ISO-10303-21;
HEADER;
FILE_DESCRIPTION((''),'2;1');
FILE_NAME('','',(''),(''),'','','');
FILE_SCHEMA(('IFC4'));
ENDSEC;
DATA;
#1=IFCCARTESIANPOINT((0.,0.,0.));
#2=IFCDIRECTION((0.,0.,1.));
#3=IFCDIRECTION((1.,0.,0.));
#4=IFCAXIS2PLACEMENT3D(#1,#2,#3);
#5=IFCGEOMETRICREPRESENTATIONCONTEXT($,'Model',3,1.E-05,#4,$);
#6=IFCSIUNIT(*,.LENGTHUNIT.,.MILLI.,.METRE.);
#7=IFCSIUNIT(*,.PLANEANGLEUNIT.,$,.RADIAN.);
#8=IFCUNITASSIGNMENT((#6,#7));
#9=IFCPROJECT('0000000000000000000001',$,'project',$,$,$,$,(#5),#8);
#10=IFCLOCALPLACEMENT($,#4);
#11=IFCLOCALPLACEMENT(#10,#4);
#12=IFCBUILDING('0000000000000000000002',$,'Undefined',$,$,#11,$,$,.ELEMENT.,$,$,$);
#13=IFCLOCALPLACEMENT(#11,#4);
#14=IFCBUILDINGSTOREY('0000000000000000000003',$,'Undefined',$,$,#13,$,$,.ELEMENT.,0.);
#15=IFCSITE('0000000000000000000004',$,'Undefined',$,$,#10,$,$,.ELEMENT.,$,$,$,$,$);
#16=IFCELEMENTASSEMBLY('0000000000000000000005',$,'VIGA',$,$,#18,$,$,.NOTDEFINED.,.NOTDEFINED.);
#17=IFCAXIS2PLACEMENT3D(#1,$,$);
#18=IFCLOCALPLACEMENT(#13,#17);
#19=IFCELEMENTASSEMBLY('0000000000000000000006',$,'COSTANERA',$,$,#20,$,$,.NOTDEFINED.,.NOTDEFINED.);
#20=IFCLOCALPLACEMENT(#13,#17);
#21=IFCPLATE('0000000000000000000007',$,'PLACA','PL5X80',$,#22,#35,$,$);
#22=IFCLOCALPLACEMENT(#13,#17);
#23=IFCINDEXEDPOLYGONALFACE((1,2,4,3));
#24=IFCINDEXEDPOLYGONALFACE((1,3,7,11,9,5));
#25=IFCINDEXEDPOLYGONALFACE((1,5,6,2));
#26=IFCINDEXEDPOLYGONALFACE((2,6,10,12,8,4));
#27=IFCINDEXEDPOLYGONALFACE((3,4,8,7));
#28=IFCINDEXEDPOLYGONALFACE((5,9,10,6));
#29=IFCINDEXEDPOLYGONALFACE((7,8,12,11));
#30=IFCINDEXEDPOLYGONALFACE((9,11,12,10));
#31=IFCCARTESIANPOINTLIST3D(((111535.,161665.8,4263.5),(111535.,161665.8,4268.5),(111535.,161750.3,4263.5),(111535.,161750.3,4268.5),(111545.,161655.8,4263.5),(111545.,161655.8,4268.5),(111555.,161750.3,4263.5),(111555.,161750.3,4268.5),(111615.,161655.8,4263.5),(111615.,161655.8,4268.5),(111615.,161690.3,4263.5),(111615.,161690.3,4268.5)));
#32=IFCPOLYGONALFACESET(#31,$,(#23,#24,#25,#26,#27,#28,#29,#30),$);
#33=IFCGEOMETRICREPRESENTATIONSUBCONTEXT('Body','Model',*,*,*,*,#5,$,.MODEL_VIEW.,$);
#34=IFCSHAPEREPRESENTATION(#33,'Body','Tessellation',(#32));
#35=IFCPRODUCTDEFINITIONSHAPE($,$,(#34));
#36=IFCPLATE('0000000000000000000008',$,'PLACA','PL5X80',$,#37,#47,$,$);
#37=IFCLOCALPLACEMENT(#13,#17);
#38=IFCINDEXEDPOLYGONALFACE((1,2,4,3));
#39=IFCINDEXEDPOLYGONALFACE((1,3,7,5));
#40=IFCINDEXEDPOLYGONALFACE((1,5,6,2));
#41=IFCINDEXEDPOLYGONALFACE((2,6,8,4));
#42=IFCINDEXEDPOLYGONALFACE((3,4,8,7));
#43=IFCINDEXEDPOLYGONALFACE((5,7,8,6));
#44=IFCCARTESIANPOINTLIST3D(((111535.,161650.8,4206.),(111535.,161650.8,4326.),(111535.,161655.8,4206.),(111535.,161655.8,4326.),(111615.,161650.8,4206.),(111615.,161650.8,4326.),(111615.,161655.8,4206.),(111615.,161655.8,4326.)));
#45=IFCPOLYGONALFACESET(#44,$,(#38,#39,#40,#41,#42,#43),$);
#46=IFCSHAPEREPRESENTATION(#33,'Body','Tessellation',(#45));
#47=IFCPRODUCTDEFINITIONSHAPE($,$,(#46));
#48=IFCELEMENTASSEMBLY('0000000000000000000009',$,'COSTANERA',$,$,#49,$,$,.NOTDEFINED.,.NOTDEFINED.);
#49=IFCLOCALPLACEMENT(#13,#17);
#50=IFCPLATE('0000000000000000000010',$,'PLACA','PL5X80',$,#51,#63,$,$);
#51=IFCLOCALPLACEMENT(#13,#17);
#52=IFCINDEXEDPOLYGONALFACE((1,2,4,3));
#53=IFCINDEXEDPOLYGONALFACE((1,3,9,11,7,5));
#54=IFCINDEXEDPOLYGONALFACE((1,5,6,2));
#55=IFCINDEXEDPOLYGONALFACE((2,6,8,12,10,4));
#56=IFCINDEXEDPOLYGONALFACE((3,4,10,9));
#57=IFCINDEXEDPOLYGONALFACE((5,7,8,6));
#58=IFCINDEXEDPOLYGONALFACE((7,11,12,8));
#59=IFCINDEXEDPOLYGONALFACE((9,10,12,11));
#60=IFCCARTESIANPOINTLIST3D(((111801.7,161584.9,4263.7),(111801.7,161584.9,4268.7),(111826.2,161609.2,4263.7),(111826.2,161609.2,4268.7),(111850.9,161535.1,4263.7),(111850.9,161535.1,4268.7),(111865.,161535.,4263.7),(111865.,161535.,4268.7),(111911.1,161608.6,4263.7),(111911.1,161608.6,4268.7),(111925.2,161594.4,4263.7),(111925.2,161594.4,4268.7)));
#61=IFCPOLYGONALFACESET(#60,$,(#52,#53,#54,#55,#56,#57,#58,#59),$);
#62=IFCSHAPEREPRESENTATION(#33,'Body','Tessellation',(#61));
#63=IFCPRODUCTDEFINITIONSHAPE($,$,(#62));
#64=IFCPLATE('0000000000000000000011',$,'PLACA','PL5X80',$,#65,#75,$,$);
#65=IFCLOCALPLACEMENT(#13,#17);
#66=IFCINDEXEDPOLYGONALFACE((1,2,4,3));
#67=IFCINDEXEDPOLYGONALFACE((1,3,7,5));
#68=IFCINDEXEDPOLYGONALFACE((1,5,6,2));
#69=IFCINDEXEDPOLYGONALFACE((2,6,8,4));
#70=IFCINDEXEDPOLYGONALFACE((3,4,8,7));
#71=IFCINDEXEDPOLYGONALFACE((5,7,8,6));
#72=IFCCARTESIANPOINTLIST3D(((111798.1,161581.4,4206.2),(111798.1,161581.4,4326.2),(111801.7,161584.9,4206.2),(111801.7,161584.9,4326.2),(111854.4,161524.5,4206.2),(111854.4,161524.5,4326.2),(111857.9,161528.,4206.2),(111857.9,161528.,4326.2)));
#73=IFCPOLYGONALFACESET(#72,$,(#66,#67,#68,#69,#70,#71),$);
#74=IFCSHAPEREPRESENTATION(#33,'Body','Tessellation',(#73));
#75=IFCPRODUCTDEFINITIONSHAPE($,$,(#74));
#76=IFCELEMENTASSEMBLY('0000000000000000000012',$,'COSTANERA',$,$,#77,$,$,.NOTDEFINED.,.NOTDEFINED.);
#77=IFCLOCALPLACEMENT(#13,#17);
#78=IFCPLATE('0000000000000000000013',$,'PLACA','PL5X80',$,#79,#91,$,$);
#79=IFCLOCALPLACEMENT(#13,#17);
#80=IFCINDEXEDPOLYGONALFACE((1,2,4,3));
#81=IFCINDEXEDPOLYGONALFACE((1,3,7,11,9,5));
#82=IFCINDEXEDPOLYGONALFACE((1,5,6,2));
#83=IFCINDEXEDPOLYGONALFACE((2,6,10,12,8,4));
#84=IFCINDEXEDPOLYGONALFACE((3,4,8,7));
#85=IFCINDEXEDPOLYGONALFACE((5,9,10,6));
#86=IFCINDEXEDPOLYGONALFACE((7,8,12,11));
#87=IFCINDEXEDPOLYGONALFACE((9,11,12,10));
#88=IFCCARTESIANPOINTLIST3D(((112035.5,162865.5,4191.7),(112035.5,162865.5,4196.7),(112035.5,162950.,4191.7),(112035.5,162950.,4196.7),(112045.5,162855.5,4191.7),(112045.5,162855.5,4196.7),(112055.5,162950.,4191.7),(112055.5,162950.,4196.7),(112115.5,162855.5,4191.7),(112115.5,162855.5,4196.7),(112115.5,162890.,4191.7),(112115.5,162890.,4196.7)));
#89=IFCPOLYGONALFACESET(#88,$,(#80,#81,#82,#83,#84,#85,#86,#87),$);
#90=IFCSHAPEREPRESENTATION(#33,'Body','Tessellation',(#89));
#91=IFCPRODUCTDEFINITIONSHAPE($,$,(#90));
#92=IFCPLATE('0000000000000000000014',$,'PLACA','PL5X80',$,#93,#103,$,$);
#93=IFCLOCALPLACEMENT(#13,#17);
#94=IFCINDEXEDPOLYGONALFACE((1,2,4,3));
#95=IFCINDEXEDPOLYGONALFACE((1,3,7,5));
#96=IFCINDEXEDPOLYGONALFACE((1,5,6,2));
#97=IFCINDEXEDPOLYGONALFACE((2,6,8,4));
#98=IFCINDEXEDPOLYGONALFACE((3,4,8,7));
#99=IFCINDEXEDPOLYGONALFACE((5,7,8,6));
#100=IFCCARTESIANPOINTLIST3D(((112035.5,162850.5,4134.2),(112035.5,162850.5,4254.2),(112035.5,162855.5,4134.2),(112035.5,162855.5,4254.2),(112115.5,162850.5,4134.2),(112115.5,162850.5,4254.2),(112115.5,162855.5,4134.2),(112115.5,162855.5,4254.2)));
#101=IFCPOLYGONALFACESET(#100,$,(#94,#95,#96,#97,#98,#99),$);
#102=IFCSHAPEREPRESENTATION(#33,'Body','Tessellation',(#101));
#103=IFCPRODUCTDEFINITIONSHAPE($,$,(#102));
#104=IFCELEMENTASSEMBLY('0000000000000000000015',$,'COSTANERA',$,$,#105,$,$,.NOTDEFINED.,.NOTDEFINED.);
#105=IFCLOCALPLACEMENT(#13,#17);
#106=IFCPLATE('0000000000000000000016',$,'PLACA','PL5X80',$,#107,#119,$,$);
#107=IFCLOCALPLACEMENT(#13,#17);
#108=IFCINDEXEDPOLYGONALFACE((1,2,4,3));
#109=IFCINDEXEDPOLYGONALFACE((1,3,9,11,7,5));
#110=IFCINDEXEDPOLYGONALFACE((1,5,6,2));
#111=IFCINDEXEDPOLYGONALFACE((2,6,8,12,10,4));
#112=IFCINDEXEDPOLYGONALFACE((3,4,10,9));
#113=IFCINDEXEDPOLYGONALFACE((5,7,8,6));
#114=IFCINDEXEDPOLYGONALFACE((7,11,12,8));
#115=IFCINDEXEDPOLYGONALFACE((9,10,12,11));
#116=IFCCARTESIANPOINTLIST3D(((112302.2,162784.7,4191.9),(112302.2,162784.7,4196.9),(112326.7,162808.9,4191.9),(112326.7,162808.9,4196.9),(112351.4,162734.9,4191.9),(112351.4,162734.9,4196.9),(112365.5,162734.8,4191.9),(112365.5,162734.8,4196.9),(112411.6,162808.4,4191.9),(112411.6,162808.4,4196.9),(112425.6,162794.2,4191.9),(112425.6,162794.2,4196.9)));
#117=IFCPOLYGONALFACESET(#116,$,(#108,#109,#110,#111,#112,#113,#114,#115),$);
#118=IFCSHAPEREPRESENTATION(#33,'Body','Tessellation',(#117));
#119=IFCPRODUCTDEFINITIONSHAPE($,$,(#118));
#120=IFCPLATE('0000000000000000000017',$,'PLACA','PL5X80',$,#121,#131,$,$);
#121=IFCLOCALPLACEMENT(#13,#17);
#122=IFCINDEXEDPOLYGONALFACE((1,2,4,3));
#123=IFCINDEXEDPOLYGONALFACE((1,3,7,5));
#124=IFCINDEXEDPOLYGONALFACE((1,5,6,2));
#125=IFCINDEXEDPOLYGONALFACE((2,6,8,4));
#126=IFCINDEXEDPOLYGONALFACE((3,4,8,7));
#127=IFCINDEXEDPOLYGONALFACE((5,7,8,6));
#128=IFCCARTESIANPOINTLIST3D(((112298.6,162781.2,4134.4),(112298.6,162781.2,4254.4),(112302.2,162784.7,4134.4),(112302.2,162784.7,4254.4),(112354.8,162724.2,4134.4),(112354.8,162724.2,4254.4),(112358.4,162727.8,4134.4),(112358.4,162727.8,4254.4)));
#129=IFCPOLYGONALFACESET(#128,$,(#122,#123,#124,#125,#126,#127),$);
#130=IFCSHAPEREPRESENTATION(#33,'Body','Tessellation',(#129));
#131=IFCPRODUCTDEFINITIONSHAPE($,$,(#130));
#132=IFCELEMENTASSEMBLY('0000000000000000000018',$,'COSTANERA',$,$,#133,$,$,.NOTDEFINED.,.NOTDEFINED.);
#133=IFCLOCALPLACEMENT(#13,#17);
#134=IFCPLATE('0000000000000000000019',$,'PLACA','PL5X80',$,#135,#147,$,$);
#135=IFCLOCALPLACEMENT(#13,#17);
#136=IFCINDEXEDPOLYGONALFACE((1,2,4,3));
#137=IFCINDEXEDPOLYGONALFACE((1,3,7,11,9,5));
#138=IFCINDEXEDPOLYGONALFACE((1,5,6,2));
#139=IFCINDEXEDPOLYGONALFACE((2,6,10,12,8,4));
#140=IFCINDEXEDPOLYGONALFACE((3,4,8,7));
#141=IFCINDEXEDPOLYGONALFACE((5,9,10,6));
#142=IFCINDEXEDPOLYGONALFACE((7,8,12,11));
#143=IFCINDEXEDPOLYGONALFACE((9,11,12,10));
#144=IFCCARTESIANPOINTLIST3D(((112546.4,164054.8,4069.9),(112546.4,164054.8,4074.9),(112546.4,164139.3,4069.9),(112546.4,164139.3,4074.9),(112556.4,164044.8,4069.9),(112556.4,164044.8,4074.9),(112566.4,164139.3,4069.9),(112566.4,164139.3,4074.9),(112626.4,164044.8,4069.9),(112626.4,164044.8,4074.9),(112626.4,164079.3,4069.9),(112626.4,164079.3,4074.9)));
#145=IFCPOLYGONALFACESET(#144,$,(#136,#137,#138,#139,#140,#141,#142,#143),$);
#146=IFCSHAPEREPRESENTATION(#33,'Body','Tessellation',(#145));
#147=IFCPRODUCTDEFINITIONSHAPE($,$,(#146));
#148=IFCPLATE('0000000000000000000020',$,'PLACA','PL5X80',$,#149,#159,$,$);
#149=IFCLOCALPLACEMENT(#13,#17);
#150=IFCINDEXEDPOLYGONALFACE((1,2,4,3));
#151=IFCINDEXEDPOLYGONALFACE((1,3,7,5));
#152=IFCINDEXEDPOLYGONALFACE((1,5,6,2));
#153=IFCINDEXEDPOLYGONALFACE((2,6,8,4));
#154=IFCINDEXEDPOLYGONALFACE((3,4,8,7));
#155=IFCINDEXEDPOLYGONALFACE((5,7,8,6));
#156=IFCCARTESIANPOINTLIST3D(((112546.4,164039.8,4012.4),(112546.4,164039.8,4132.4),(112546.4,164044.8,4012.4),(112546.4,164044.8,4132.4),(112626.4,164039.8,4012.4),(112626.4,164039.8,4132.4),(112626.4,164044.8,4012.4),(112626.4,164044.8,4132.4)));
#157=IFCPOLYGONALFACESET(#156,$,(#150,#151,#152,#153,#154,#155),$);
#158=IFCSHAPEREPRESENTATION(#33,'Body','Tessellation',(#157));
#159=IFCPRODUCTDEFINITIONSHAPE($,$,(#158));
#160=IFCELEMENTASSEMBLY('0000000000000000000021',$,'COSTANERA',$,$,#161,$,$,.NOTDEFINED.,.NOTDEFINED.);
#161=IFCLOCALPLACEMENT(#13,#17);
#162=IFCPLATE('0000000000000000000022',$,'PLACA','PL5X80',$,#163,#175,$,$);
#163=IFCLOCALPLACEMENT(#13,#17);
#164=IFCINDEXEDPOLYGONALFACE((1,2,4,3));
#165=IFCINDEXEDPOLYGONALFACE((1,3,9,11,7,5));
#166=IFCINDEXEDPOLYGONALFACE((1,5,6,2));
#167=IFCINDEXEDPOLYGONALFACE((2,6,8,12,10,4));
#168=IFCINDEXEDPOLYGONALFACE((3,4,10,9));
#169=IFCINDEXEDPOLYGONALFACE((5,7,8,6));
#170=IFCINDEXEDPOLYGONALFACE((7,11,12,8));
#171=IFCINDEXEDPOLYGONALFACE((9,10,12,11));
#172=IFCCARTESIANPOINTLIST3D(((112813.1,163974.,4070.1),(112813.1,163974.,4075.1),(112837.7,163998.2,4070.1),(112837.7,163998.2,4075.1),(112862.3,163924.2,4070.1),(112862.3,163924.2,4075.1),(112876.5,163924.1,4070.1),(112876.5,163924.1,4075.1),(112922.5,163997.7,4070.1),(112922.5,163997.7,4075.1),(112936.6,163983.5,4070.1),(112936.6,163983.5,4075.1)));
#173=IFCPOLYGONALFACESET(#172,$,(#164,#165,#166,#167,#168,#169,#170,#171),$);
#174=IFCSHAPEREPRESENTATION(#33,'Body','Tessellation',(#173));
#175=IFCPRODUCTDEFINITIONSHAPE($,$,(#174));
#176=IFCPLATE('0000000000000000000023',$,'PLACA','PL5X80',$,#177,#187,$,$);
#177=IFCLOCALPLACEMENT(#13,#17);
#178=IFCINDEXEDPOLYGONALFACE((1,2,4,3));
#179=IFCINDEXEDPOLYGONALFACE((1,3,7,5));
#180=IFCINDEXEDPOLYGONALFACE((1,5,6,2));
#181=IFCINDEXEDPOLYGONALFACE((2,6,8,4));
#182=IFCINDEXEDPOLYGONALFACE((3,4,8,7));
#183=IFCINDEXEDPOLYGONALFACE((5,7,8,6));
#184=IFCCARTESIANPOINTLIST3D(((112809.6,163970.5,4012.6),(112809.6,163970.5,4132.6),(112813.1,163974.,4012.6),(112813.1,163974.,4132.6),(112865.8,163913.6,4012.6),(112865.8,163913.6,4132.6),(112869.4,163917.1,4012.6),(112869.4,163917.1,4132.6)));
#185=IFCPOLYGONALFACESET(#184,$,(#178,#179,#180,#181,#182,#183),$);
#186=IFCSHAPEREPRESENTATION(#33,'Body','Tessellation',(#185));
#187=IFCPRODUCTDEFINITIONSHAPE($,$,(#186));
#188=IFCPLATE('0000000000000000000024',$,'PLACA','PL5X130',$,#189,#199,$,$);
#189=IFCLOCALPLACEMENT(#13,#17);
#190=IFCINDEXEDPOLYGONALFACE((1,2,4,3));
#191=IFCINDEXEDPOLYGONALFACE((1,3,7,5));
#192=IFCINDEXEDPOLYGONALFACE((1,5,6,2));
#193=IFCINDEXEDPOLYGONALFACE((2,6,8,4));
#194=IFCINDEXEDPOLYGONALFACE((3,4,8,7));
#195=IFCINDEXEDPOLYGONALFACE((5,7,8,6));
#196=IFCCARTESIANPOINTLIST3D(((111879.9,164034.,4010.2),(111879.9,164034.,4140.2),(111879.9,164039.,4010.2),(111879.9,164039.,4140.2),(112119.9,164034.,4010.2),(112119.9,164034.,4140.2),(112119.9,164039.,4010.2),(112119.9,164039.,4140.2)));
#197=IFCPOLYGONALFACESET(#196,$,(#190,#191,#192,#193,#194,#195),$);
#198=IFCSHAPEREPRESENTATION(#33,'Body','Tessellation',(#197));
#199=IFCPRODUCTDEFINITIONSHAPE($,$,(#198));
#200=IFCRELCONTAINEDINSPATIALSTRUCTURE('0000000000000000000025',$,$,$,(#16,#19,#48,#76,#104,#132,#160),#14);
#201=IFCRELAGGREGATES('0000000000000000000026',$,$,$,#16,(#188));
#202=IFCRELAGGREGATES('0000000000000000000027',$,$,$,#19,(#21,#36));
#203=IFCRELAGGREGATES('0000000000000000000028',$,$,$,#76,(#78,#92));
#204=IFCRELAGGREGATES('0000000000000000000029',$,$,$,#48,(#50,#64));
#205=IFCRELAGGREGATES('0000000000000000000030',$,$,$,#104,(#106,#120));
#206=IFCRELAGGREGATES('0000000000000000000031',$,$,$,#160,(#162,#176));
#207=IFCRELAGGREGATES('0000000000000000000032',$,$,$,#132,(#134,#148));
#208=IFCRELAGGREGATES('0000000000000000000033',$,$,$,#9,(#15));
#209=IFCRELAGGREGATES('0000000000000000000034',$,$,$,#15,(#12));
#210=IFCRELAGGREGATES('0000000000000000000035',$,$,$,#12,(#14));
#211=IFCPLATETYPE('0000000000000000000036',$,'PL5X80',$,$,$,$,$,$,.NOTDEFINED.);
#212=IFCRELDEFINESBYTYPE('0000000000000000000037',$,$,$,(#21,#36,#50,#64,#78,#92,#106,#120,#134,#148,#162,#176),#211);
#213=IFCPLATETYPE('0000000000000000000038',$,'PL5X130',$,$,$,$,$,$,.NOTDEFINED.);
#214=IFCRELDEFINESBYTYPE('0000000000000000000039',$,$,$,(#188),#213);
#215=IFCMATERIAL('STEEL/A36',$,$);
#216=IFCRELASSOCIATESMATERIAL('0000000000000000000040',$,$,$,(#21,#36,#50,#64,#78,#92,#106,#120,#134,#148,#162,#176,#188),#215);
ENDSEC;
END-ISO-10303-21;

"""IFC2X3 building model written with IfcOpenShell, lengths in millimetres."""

from ifc_helpers import new_model, si_unit, frame, origin_with_axes, place, context, subcontext, project, spatial, polyline, outline, extrude, material, type_object, element, aggregate, save


model = new_model("IFC2X3")

# Units and contexts
model_context = context("Model", 3, precision=1e-05, world=origin_with_axes())
body_context = subcontext(model_context, "Body", "Model", "MODEL_VIEW")
ifc_project = project(units=[si_unit("LENGTHUNIT", "METRE", prefix="MILLI"), si_unit("PLANEANGLEUNIT", "RADIAN")], contexts=[model_context])

# Site, building, storey
site_placement = place(None, origin_with_axes())
site = spatial("IfcSite", under=ifc_project, at=site_placement, Name="Undefined", CompositionType="ELEMENT")
building_placement = place(site_placement, origin_with_axes())
building = spatial("IfcBuilding", under=site, at=building_placement, Name="Undefined", CompositionType="ELEMENT")
storey_placement = place(building_placement, origin_with_axes())
storey = spatial("IfcBuildingStorey", under=building, at=storey_placement, Name="Undefined", CompositionType="ELEMENT", Elevation=0.0)

# Shared definitions
ifc_material_1 = material(Name="STEEL/A36")

# Element assembly
assembly_1_placement = place(storey_placement, origin_with_axes())
assembly_1 = element("IfcElementAssembly", 1, at=assembly_1_placement, inside=storey, Name="VIGA", AssemblyPlace="NOTDEFINED", PredefinedType="NOTDEFINED")

# Element assemblies, plates
assembly_2_placement = place(storey_placement, origin_with_axes())
assembly_2 = element("IfcElementAssembly", 2, at=assembly_2_placement, inside=storey, Name="COSTANERA", AssemblyPlace="NOTDEFINED", PredefinedType="NOTDEFINED")
plate_type_1 = type_object("IfcPlateType", Name="PL5X80", PredefinedType="NOTDEFINED")
plate_1_placement = place(assembly_2_placement, frame((111615.0, 161655.8, 4266.0), z_axis=(-0.000004, -0.000004, -1.0), x_axis=(-1.0, 0.0, 0.000004)))
plate_1 = element("IfcPlate", 3, at=plate_1_placement, type_object=plate_type_1, material=ifc_material_1, Name="PLACA", Description="PL5X80", context=body_context, shape_type="SweptSolid", body=[
    extrude(outline(polyline([(0.0, 0.0), (70.0, 0.0), (80.0, 10.0), (80.0, 94.5), (60.0, 94.5), (0.0, 34.5), (0.0, 0.0)])), frame((0.0, 0.0, -2.5), z_axis=(0.0, 0.0, 1.0), x_axis=(1.0, 0.0, 0.0)), (0.0, 0.0, 1.0), 5.0),
])
plate_2_placement = place(assembly_2_placement, frame((111615.0, 161653.3, 4206.0), z_axis=(0.0, 1.0, -0.000004), x_axis=(-1.0, 0.0, 0.000004)))
plate_2 = element("IfcPlate", 4, at=plate_2_placement, type_object=plate_type_1, material=ifc_material_1, Name="PLACA", Description="PL5X80", context=body_context, shape_type="SweptSolid", body=[
    extrude(outline(polyline([(0.0, 0.0), (80.0, 0.0), (80.0, 120.0), (0.0, 120.0), (0.0, 0.0)])), frame((0.0, 0.0, -2.5), z_axis=(0.0, 0.0, 1.0), x_axis=(1.0, 0.0, 0.0)), (0.0, 0.0, 1.0), 5.0),
])
assembly_3_placement = place(storey_placement, origin_with_axes())
assembly_3 = element("IfcElementAssembly", 5, at=assembly_3_placement, inside=storey, Name="COSTANERA", AssemblyPlace="NOTDEFINED", PredefinedType="NOTDEFINED")
plate_3_placement = place(assembly_3_placement, frame((111801.7, 161584.9, 4266.2), z_axis=(0.000004, 0.000004, 1.0), x_axis=(0.702758, -0.711429, 0.0)))
plate_3 = element("IfcPlate", 6, at=plate_3_placement, type_object=plate_type_1, material=ifc_material_1, Name="PLACA", Description="PL5X80", context=body_context, shape_type="SweptSolid", body=[
    extrude(outline(polyline([(0.0, 0.0), (70.0, 0.0), (80.0, 10.0), (80.0, 94.5), (60.0, 94.5), (0.0, 34.5), (0.0, 0.0)])), frame((0.0, 0.0, -2.5), z_axis=(0.0, 0.0, 1.0), x_axis=(1.0, 0.0, 0.0)), (0.0, 0.0, 1.0), 5.0),
])
plate_4_placement = place(assembly_3_placement, frame((111799.9, 161583.2, 4326.2), z_axis=(0.711429, 0.702758, -0.000006), x_axis=(0.702758, -0.711429, 0.0)))
plate_4 = element("IfcPlate", 7, at=plate_4_placement, type_object=plate_type_1, material=ifc_material_1, Name="PLACA", Description="PL5X80", context=body_context, shape_type="SweptSolid", body=[
    extrude(outline(polyline([(0.0, 0.0), (80.0, 0.0), (80.0, 120.0), (0.0, 120.0), (0.0, 0.0)])), frame((0.0, 0.0, -2.5), z_axis=(0.0, 0.0, 1.0), x_axis=(1.0, 0.0, 0.0)), (0.0, 0.0, 1.0), 5.0),
])
assembly_4_placement = place(storey_placement, origin_with_axes())
assembly_4 = element("IfcElementAssembly", 8, at=assembly_4_placement, inside=storey, Name="COSTANERA", AssemblyPlace="NOTDEFINED", PredefinedType="NOTDEFINED")
plate_5_placement = place(assembly_4_placement, frame((112115.5, 162855.5, 4194.2), z_axis=(-0.000004, -0.000004, -1.0), x_axis=(-1.0, 0.0, 0.000004)))
plate_5 = element("IfcPlate", 9, at=plate_5_placement, type_object=plate_type_1, material=ifc_material_1, Name="PLACA", Description="PL5X80", context=body_context, shape_type="SweptSolid", body=[
    extrude(outline(polyline([(0.0, 0.0), (70.0, 0.0), (80.0, 10.0), (80.0, 94.5), (60.0, 94.5), (0.0, 34.5), (0.0, 0.0)])), frame((0.0, 0.0, -2.5), z_axis=(0.0, 0.0, 1.0), x_axis=(1.0, 0.0, 0.0)), (0.0, 0.0, 1.0), 5.0),
])
plate_6_placement = place(assembly_4_placement, frame((112115.5, 162853.0, 4134.2), z_axis=(0.0, 1.0, -0.000004), x_axis=(-1.0, 0.0, 0.000004)))
plate_6 = element("IfcPlate", 10, at=plate_6_placement, type_object=plate_type_1, material=ifc_material_1, Name="PLACA", Description="PL5X80", context=body_context, shape_type="SweptSolid", body=[
    extrude(outline(polyline([(0.0, 0.0), (80.0, 0.0), (80.0, 120.0), (0.0, 120.0), (0.0, 0.0)])), frame((0.0, 0.0, -2.5), z_axis=(0.0, 0.0, 1.0), x_axis=(1.0, 0.0, 0.0)), (0.0, 0.0, 1.0), 5.0),
])
assembly_5_placement = place(storey_placement, origin_with_axes())
assembly_5 = element("IfcElementAssembly", 11, at=assembly_5_placement, inside=storey, Name="COSTANERA", AssemblyPlace="NOTDEFINED", PredefinedType="NOTDEFINED")
plate_7_placement = place(assembly_5_placement, frame((112302.2, 162784.7, 4194.4), z_axis=(0.000004, 0.000004, 1.0), x_axis=(0.702758, -0.711429, 0.0)))
plate_7 = element("IfcPlate", 12, at=plate_7_placement, type_object=plate_type_1, material=ifc_material_1, Name="PLACA", Description="PL5X80", context=body_context, shape_type="SweptSolid", body=[
    extrude(outline(polyline([(0.0, 0.0), (70.0, 0.0), (80.0, 10.0), (80.0, 94.5), (60.0, 94.5), (0.0, 34.5), (0.0, 0.0)])), frame((0.0, 0.0, -2.5), z_axis=(0.0, 0.0, 1.0), x_axis=(1.0, 0.0, 0.0)), (0.0, 0.0, 1.0), 5.0),
])
plate_8_placement = place(assembly_5_placement, frame((112300.4, 162782.9, 4254.4), z_axis=(0.711429, 0.702758, -0.000006), x_axis=(0.702758, -0.711429, 0.0)))
plate_8 = element("IfcPlate", 13, at=plate_8_placement, type_object=plate_type_1, material=ifc_material_1, Name="PLACA", Description="PL5X80", context=body_context, shape_type="SweptSolid", body=[
    extrude(outline(polyline([(0.0, 0.0), (80.0, 0.0), (80.0, 120.0), (0.0, 120.0), (0.0, 0.0)])), frame((0.0, 0.0, -2.5), z_axis=(0.0, 0.0, 1.0), x_axis=(1.0, 0.0, 0.0)), (0.0, 0.0, 1.0), 5.0),
])
assembly_6_placement = place(storey_placement, origin_with_axes())
assembly_6 = element("IfcElementAssembly", 14, at=assembly_6_placement, inside=storey, Name="COSTANERA", AssemblyPlace="NOTDEFINED", PredefinedType="NOTDEFINED")
plate_9_placement = place(assembly_6_placement, frame((112626.4, 164044.8, 4072.4), z_axis=(-0.000004, -0.000004, -1.0), x_axis=(-1.0, 0.0, 0.000004)))
plate_9 = element("IfcPlate", 15, at=plate_9_placement, type_object=plate_type_1, material=ifc_material_1, Name="PLACA", Description="PL5X80", context=body_context, shape_type="SweptSolid", body=[
    extrude(outline(polyline([(0.0, 0.0), (70.0, 0.0), (80.0, 10.0), (80.0, 94.5), (60.0, 94.5), (0.0, 34.5), (0.0, 0.0)])), frame((0.0, 0.0, -2.5), z_axis=(0.0, 0.0, 1.0), x_axis=(1.0, 0.0, 0.0)), (0.0, 0.0, 1.0), 5.0),
])
plate_10_placement = place(assembly_6_placement, frame((112626.4, 164042.3, 4012.4), z_axis=(0.0, 1.0, -0.000004), x_axis=(-1.0, 0.0, 0.000004)))
plate_10 = element("IfcPlate", 16, at=plate_10_placement, type_object=plate_type_1, material=ifc_material_1, Name="PLACA", Description="PL5X80", context=body_context, shape_type="SweptSolid", body=[
    extrude(outline(polyline([(0.0, 0.0), (80.0, 0.0), (80.0, 120.0), (0.0, 120.0), (0.0, 0.0)])), frame((0.0, 0.0, -2.5), z_axis=(0.0, 0.0, 1.0), x_axis=(1.0, 0.0, 0.0)), (0.0, 0.0, 1.0), 5.0),
])
assembly_7_placement = place(storey_placement, origin_with_axes())
assembly_7 = element("IfcElementAssembly", 17, at=assembly_7_placement, inside=storey, Name="COSTANERA", AssemblyPlace="NOTDEFINED", PredefinedType="NOTDEFINED")
plate_11_placement = place(assembly_7_placement, frame((112813.1, 163974.0, 4072.6), z_axis=(0.000004, 0.000004, 1.0), x_axis=(0.702758, -0.711429, 0.0)))
plate_11 = element("IfcPlate", 18, at=plate_11_placement, type_object=plate_type_1, material=ifc_material_1, Name="PLACA", Description="PL5X80", context=body_context, shape_type="SweptSolid", body=[
    extrude(outline(polyline([(0.0, 0.0), (70.0, 0.0), (80.0, 10.0), (80.0, 94.5), (60.0, 94.5), (0.0, 34.5), (0.0, 0.0)])), frame((0.0, 0.0, -2.5), z_axis=(0.0, 0.0, 1.0), x_axis=(1.0, 0.0, 0.0)), (0.0, 0.0, 1.0), 5.0),
])
plate_12_placement = place(assembly_7_placement, frame((112811.4, 163972.2, 4132.6), z_axis=(0.711429, 0.702758, -0.000006), x_axis=(0.702758, -0.711429, 0.0)))
plate_12 = element("IfcPlate", 19, at=plate_12_placement, type_object=plate_type_1, material=ifc_material_1, Name="PLACA", Description="PL5X80", context=body_context, shape_type="SweptSolid", body=[
    extrude(outline(polyline([(0.0, 0.0), (80.0, 0.0), (80.0, 120.0), (0.0, 120.0), (0.0, 0.0)])), frame((0.0, 0.0, -2.5), z_axis=(0.0, 0.0, 1.0), x_axis=(1.0, 0.0, 0.0)), (0.0, 0.0, 1.0), 5.0),
])

# Plate
plate_type_2 = type_object("IfcPlateType", Name="PL5X130", PredefinedType="NOTDEFINED")
plate_13_placement = place(assembly_1_placement, frame((111879.9, 164036.5, 4140.2), z_axis=(0.0, 1.0, 0.0), x_axis=(1.0, 0.0, 0.000002)))
plate_13 = element("IfcPlate", 20, at=plate_13_placement, type_object=plate_type_2, material=ifc_material_1, Name="PLACA", Description="PL5X130", context=body_context, shape_type="SweptSolid", body=[
    extrude(outline(polyline([(0.0, 0.0), (240.0, 0.0), (240.0, 130.0), (0.0, 130.0), (0.0, 0.0)])), frame((0.0, 0.0, -2.5), z_axis=(0.0, 0.0, 1.0), x_axis=(1.0, 0.0, 0.0)), (0.0, 0.0, 1.0), 5.0),
])

aggregate(assembly_1, [plate_13])

aggregate(assembly_2, [plate_1, plate_2])
aggregate(assembly_4, [plate_5, plate_6])
aggregate(assembly_3, [plate_3, plate_4])
aggregate(assembly_5, [plate_7, plate_8])
aggregate(assembly_7, [plate_11, plate_12])
aggregate(assembly_6, [plate_9, plate_10])

save(model, "model.ifc")
